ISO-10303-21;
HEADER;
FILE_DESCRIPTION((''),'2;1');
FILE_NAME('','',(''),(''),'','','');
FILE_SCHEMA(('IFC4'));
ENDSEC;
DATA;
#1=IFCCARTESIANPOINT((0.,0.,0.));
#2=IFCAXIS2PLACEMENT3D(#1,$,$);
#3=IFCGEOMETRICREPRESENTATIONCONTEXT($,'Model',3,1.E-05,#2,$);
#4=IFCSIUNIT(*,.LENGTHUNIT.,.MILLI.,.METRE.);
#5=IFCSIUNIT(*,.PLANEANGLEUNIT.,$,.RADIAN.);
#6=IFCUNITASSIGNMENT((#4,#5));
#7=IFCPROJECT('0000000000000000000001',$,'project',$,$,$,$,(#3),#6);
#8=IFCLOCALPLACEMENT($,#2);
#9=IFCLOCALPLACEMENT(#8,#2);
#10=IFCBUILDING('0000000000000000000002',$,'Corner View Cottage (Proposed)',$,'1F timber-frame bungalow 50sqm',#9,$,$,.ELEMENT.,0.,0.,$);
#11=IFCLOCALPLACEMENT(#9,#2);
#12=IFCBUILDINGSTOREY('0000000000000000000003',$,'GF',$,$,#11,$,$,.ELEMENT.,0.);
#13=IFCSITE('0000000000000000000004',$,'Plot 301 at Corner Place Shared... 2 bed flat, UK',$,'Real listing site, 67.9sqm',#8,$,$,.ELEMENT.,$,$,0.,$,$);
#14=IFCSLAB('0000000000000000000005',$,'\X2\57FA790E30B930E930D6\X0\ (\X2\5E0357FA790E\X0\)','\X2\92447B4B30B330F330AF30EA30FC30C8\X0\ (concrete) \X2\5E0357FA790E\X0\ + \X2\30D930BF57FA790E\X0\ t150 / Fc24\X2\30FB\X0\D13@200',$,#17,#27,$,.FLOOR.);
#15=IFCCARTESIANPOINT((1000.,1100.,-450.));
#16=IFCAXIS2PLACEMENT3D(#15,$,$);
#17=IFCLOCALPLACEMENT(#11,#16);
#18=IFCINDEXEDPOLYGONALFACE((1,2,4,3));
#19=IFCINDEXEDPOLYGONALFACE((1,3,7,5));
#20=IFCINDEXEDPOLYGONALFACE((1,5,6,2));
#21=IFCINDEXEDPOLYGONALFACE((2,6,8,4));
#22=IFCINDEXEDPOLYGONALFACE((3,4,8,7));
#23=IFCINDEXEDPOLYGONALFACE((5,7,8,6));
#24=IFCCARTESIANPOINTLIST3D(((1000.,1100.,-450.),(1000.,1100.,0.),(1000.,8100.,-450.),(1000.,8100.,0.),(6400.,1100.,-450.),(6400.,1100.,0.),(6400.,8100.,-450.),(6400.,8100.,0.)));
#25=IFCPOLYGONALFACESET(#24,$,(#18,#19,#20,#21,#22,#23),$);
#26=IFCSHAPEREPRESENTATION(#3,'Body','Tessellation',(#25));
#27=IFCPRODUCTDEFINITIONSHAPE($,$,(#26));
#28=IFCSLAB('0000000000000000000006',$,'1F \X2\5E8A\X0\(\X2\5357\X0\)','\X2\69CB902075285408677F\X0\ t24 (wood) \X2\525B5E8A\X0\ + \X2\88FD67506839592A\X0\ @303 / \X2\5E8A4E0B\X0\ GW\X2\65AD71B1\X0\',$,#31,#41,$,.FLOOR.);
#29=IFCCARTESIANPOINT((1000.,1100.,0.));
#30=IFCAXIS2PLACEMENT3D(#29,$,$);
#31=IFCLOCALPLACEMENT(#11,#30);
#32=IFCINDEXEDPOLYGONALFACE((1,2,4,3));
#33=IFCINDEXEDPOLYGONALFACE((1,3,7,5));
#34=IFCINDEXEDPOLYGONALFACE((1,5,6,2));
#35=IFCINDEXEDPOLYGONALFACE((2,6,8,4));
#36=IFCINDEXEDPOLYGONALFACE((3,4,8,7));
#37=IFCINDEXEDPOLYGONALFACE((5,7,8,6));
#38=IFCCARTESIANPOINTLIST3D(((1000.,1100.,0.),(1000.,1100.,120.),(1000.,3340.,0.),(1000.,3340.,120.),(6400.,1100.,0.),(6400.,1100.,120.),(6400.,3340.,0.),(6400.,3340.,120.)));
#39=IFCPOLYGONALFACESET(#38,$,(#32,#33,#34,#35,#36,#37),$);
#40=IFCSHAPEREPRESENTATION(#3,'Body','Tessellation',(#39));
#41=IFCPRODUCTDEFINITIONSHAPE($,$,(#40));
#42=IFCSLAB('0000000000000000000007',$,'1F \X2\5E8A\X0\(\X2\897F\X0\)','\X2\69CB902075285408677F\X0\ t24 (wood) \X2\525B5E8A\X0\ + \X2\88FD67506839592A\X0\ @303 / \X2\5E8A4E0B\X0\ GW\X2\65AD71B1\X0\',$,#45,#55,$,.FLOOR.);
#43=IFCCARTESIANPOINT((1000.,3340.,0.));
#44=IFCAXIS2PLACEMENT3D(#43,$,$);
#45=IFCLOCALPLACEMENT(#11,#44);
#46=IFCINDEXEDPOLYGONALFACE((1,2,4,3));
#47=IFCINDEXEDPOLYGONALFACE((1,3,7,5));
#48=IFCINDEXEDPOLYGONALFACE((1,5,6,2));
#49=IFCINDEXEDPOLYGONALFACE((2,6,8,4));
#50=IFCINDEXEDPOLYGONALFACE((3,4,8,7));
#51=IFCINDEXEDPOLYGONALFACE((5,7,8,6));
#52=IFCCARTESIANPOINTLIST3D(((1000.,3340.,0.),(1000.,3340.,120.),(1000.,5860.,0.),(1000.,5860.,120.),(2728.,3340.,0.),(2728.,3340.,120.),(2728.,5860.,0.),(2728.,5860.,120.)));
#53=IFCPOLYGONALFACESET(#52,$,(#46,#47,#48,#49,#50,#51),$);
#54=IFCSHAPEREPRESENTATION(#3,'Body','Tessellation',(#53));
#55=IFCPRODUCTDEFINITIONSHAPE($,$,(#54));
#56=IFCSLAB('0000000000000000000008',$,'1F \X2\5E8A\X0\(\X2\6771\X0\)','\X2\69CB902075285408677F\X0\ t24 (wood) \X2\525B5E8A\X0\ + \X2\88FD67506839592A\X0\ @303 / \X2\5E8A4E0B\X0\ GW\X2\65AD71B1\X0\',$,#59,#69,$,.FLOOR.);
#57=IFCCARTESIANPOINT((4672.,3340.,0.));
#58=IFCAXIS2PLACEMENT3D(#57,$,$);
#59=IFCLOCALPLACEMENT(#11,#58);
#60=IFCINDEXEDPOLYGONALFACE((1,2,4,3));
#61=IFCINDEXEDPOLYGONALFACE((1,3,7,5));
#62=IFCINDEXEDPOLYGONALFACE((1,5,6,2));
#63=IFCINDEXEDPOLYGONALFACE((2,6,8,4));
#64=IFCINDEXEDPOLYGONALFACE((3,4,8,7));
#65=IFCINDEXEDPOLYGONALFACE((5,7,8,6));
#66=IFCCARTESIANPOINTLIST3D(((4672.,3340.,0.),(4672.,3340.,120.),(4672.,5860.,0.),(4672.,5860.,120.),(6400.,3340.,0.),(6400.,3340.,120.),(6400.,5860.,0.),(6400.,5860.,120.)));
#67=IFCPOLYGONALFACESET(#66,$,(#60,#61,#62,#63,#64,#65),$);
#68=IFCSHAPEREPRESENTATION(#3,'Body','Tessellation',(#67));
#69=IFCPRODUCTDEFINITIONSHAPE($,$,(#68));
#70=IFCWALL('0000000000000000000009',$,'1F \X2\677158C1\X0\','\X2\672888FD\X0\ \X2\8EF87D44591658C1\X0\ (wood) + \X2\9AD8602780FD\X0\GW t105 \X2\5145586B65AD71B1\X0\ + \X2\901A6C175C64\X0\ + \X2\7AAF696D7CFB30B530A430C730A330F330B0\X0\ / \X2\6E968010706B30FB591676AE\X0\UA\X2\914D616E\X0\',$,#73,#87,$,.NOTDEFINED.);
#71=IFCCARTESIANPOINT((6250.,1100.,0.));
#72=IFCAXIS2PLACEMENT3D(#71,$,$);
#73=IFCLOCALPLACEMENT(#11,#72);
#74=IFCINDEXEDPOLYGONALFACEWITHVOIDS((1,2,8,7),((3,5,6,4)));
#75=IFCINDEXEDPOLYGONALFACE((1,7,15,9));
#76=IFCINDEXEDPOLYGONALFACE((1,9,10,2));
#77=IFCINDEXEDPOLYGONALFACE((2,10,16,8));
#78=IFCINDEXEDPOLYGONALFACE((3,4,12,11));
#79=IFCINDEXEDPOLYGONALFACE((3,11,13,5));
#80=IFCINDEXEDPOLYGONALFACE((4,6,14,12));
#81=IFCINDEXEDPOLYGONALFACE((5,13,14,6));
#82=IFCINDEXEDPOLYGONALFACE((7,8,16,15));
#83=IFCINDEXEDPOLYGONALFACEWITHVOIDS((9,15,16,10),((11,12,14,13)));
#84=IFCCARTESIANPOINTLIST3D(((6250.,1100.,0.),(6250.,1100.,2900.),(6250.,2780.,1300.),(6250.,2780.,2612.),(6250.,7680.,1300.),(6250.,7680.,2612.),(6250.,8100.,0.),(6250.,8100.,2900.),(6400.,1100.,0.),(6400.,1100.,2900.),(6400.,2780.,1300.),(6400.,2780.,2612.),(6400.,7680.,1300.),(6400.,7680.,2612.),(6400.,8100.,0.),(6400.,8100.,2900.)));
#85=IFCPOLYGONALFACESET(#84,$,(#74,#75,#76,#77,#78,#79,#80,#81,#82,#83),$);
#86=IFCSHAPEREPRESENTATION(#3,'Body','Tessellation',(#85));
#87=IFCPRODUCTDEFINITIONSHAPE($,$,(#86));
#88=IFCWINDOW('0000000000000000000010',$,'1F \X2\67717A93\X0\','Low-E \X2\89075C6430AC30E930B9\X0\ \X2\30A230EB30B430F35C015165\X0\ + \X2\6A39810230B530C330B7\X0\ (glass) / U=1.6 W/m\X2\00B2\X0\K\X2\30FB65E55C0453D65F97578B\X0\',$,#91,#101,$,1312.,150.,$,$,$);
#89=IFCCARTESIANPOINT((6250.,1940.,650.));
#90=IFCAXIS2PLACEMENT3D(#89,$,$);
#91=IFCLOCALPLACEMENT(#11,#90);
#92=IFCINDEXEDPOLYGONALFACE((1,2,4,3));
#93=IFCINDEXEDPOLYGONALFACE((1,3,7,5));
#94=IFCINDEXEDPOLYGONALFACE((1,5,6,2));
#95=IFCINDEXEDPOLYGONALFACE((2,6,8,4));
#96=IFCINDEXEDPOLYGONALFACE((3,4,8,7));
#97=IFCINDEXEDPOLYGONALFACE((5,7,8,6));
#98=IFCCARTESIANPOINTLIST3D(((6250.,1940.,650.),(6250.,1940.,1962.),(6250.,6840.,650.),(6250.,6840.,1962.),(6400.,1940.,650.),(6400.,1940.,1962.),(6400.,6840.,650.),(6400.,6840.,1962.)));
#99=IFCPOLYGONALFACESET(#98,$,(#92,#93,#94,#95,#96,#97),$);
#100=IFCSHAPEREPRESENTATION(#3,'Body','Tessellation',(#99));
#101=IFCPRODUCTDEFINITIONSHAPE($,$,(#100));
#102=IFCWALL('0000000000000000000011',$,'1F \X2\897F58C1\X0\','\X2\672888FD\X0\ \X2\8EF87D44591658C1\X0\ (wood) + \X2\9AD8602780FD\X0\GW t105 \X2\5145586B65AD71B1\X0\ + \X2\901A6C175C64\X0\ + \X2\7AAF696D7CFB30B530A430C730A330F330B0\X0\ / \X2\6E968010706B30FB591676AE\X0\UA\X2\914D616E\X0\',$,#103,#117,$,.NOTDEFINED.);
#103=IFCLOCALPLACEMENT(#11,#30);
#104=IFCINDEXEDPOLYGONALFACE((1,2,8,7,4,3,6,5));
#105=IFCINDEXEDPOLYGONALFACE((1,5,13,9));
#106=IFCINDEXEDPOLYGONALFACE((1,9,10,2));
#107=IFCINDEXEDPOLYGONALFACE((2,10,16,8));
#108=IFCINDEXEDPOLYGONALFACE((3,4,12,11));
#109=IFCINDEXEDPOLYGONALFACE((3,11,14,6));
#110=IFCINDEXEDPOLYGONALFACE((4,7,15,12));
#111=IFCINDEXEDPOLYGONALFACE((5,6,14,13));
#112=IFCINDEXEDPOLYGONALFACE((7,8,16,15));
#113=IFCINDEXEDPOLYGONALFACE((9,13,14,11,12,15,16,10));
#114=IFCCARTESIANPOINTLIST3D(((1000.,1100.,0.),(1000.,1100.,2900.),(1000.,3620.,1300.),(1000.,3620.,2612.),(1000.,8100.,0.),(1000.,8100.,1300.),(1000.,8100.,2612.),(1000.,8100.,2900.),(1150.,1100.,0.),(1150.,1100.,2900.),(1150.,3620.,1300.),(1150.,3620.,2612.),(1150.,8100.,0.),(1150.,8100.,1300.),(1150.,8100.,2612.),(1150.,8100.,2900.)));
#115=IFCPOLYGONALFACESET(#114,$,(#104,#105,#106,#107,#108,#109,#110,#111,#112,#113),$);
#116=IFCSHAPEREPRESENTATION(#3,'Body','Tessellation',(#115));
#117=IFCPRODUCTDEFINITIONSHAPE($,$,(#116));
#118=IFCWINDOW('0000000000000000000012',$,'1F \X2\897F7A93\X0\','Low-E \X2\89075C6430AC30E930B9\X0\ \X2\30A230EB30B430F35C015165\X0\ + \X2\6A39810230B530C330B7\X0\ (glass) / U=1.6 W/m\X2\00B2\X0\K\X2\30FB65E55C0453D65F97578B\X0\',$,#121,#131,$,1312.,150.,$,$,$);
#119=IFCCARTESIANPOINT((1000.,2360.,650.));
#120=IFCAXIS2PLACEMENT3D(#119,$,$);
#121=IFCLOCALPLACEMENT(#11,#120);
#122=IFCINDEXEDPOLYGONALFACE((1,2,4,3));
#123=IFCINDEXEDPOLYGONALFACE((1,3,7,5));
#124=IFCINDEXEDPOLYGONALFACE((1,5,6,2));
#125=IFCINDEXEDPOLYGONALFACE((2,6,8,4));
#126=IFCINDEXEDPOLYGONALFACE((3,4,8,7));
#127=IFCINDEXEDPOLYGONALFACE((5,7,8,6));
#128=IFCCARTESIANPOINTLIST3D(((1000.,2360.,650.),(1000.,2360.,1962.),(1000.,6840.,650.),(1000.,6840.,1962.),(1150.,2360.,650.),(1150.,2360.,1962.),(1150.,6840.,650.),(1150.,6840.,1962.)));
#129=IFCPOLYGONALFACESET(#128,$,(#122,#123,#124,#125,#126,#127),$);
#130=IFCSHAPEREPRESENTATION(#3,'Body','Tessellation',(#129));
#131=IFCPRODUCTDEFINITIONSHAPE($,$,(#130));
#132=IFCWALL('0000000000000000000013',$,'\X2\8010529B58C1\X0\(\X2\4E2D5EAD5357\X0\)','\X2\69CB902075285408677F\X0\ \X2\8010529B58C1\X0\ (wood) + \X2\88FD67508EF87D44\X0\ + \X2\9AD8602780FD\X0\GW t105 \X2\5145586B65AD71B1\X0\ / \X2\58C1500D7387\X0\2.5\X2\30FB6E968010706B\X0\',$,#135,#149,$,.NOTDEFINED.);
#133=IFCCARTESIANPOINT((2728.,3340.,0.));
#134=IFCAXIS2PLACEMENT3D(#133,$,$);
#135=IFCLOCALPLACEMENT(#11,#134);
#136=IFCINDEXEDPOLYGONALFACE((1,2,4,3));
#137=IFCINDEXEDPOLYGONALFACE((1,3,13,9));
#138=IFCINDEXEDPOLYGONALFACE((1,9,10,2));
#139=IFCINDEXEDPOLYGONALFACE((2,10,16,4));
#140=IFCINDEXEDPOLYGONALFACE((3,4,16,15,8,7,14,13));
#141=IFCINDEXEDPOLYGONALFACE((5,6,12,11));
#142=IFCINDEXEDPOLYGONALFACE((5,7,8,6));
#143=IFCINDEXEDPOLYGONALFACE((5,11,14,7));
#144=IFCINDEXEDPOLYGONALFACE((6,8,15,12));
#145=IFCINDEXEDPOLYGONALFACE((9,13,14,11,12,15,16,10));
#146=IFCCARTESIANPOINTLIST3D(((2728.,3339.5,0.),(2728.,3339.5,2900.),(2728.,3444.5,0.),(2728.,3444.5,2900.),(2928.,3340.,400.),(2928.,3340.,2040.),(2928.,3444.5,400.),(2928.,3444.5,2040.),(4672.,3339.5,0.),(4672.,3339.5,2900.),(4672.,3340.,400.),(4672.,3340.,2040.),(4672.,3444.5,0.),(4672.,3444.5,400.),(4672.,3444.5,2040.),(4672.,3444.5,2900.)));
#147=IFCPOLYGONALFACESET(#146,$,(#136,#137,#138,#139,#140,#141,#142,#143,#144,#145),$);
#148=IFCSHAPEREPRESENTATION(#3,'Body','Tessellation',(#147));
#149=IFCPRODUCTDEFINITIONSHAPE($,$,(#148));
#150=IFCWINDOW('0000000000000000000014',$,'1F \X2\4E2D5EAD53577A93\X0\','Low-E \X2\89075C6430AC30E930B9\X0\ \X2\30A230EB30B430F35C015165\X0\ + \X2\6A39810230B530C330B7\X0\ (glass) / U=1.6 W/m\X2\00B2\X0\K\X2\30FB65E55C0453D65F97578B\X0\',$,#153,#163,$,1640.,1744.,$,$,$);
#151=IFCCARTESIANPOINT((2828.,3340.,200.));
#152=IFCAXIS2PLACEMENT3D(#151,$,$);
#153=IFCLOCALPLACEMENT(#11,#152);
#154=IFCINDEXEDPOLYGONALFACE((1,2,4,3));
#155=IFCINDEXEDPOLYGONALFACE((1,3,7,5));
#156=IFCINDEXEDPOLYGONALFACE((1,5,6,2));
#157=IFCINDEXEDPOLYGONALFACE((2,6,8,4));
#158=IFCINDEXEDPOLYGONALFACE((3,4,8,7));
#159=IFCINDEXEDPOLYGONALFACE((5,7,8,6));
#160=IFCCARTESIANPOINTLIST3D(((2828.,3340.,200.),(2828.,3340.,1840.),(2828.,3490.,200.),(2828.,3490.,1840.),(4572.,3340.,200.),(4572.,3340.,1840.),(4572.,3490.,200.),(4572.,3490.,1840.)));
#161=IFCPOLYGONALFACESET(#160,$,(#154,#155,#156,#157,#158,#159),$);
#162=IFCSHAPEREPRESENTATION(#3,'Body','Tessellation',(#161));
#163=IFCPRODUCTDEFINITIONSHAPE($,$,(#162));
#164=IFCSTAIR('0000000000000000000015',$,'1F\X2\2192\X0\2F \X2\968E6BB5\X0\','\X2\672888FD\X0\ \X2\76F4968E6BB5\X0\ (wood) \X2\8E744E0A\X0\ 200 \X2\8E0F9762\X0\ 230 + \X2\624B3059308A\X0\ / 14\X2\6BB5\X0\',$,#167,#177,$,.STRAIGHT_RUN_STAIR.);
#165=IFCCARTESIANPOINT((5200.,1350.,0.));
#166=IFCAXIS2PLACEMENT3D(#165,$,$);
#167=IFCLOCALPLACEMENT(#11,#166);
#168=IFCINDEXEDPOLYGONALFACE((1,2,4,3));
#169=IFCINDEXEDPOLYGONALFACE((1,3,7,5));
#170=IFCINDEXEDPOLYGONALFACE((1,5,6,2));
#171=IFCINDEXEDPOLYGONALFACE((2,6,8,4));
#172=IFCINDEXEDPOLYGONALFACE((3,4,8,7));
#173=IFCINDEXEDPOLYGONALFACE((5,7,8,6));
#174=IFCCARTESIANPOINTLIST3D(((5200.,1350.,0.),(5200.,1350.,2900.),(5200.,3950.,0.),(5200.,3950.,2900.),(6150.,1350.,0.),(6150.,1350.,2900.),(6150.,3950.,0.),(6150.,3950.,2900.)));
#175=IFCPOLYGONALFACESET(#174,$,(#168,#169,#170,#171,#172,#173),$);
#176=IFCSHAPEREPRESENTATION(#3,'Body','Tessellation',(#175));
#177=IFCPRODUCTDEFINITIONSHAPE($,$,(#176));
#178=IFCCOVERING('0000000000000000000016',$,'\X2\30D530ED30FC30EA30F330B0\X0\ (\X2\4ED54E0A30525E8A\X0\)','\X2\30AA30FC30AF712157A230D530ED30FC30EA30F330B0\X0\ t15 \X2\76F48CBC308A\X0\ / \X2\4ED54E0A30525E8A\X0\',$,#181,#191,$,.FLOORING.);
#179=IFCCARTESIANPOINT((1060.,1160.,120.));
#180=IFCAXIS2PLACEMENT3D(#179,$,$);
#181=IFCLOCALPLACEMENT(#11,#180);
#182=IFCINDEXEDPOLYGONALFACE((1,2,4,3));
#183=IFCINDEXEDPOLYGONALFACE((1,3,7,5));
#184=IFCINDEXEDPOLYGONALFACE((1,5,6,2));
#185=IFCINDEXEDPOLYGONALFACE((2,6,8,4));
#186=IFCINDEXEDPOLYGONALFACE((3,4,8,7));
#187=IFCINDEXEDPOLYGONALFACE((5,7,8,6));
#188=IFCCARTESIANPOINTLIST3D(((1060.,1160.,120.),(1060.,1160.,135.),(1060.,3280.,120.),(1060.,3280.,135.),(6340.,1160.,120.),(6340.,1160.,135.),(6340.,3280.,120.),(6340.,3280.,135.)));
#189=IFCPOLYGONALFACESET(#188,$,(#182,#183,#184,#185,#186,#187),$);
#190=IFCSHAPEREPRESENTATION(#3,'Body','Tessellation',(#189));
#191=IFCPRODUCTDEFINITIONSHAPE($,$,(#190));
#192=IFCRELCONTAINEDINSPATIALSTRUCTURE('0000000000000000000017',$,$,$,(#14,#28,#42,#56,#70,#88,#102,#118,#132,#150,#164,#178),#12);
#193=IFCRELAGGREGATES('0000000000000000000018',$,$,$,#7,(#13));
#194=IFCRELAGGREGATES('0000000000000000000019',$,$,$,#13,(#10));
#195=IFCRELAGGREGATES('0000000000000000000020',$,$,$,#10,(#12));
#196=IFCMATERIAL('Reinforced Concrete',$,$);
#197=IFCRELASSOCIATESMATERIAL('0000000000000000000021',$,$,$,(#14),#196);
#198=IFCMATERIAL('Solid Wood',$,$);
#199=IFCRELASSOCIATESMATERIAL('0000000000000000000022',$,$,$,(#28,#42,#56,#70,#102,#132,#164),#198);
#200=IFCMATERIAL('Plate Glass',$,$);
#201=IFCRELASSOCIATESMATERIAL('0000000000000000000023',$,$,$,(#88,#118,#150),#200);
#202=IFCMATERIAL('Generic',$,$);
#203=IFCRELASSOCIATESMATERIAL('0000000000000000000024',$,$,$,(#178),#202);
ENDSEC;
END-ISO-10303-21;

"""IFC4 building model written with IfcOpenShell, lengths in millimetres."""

from ifc_helpers import new_model, si_unit, frame, frame_2d, origin, place, context, project, spatial, rectangle, extrude, material, element, fill, save


model = new_model("IFC4")

# Units and contexts
model_context = context("Model", 3, precision=1e-05, world=origin())
ifc_project = project(units=[si_unit("LENGTHUNIT", "METRE", prefix="MILLI"), si_unit("PLANEANGLEUNIT", "RADIAN")], contexts=[model_context])

# Site, building, storey
site_placement = place(None, origin())
site = spatial("IfcSite", under=ifc_project, at=site_placement, Name="Plot 301 at Corner Place Shared... 2 bed flat, UK", ObjectType="Real listing site, 67.9sqm", CompositionType="ELEMENT", RefElevation=0.0)
building_placement = place(site_placement, origin())
building = spatial("IfcBuilding", under=site, at=building_placement, Name="Corner View Cottage (Proposed)", ObjectType="1F timber-frame bungalow 50sqm", CompositionType="ELEMENT", ElevationOfRefHeight=0.0, ElevationOfTerrain=0.0)
storey_placement = place(building_placement, origin())
storey = spatial("IfcBuildingStorey", under=building, at=storey_placement, Name="GF", CompositionType="ELEMENT", Elevation=0.0)

# Slabs
ifc_material_1 = material(Name="Reinforced Concrete")
slab_1_placement = place(storey_placement, frame((1000.0, 1100.0, -450.0)))
element("IfcSlab", 1, at=slab_1_placement, inside=storey, material=ifc_material_1, Name="基礎スラブ (布基礎)", Description="鉄筋コンクリート (concrete) 布基礎 + ベタ基礎 t150 / Fc24・D13@200", PredefinedType="FLOOR", context=model_context, shape_type="SweptSolid", body=[
    extrude(rectangle(XDim=5400.0, YDim=7000.0, at=frame_2d((2700.0, 3500.0))), frame((1000.0, 1100.0, -450.0)), (0.0, 0.0, 1.0), 450.0),
])
ifc_material_2 = material(Name="Solid Wood")
slab_2_placement = place(storey_placement, frame((1000.0, 1100.0, 0.0)))
element("IfcSlab", 2, at=slab_2_placement, inside=storey, material=ifc_material_2, Name="1F 床(南)", Description="構造用合板 t24 (wood) 剛床 + 製材根太 @303 / 床下 GW断熱", PredefinedType="FLOOR", context=model_context, shape_type="SweptSolid", body=[
    extrude(rectangle(XDim=5400.0, YDim=2240.0, at=frame_2d((2700.0, 1120.0))), frame((1000.0, 1100.0, 0.0)), (0.0, 0.0, 1.0), 120.0),
])
slab_3_placement = place(storey_placement, frame((1000.0, 3340.0, 0.0)))
element("IfcSlab", 3, at=slab_3_placement, inside=storey, material=ifc_material_2, Name="1F 床(西)", Description="構造用合板 t24 (wood) 剛床 + 製材根太 @303 / 床下 GW断熱", PredefinedType="FLOOR", context=model_context, shape_type="SweptSolid", body=[
    extrude(rectangle(XDim=1728.0, YDim=2520.0, at=frame_2d((864.0, 1260.0))), frame((1000.0, 3340.0, 0.0)), (0.0, 0.0, 1.0), 120.0),
])
slab_4_placement = place(storey_placement, frame((4672.0, 3340.0, 0.0)))
element("IfcSlab", 4, at=slab_4_placement, inside=storey, material=ifc_material_2, Name="1F 床(東)", Description="構造用合板 t24 (wood) 剛床 + 製材根太 @303 / 床下 GW断熱", PredefinedType="FLOOR", context=model_context, shape_type="SweptSolid", body=[
    extrude(rectangle(XDim=1728.0, YDim=2520.0, at=frame_2d((864.0, 1260.0))), frame((4672.0, 3340.0, 0.0)), (0.0, 0.0, 1.0), 120.0),
])
ifc_material_3 = material(Name="Generic")

# Shared definitions
ifc_material_4 = material(Name="Plate Glass")

# Walls, openings, windows
wall_1_placement = place(storey_placement, frame((6250.0, 1100.0, 0.0)))
wall_1 = element("IfcWall", 5, at=wall_1_placement, inside=storey, material=ifc_material_2, Name="1F 東壁", Description="木製 軸組外壁 (wood) + 高性能GW t105 充填断熱 + 通気層 + 窯業系サイディング / 準耐火・外皮UA配慮", PredefinedType="NOTDEFINED", context=model_context, shape_type="SweptSolid", body=[
    extrude(rectangle(XDim=150.0, YDim=7000.0, at=frame_2d((75.0, 3500.0))), frame((6250.0, 1100.0, 0.0)), (0.0, 0.0, 1.0), 2900.0),
])
opening_1_placement = place(storey_placement, frame((6250.0, 1940.0, 650.0)))
opening_1 = element("IfcOpeningElement", 6, at=opening_1_placement, cuts=wall_1, PredefinedType="NOTDEFINED", context=model_context, shape_type="SweptSolid", body=[
    extrude(rectangle(XDim=150.0, YDim=4900.0, at=frame_2d((75.0, 2450.0))), frame((6250.0, 1940.0, 650.0)), (0.0, 0.0, 1.0), 1312.0),
])
window_1_placement = place(storey_placement, frame((6250.0, 1940.0, 650.0)))
window_1 = element("IfcWindow", 7, at=window_1_placement, inside=storey, material=ifc_material_4, Name="1F 東窓", Description="Low-E 複層ガラス アルゴン封入 + 樹脂サッシ (glass) / U=1.6 W/m²K・日射取得型", OverallHeight=1312.0, OverallWidth=150.0, context=model_context, shape_type="SweptSolid", body=[
    extrude(rectangle(XDim=150.0, YDim=4900.0, at=frame_2d((75.0, 2450.0))), frame((6250.0, 1940.0, 650.0)), (0.0, 0.0, 1.0), 1312.0),
])
fill(opening_1, window_1)
wall_2_placement = place(storey_placement, frame((1000.0, 1100.0, 0.0)))
wall_2 = element("IfcWall", 8, at=wall_2_placement, inside=storey, material=ifc_material_2, Name="1F 西壁", Description="木製 軸組外壁 (wood) + 高性能GW t105 充填断熱 + 通気層 + 窯業系サイディング / 準耐火・外皮UA配慮", PredefinedType="NOTDEFINED", context=model_context, shape_type="SweptSolid", body=[
    extrude(rectangle(XDim=150.0, YDim=7000.0, at=frame_2d((75.0, 3500.0))), frame((1000.0, 1100.0, 0.0)), (0.0, 0.0, 1.0), 2900.0),
])
opening_2_placement = place(storey_placement, frame((1000.0, 2360.0, 650.0)))
opening_2 = element("IfcOpeningElement", 9, at=opening_2_placement, cuts=wall_2, PredefinedType="NOTDEFINED", context=model_context, shape_type="SweptSolid", body=[
    extrude(rectangle(XDim=150.0, YDim=4480.0, at=frame_2d((75.0, 2240.0))), frame((1000.0, 2360.0, 650.0)), (0.0, 0.0, 1.0), 1312.0),
])
window_2_placement = place(storey_placement, frame((1000.0, 2360.0, 650.0)))
window_2 = element("IfcWindow", 10, at=window_2_placement, inside=storey, material=ifc_material_4, Name="1F 西窓", Description="Low-E 複層ガラス アルゴン封入 + 樹脂サッシ (glass) / U=1.6 W/m²K・日射取得型", OverallHeight=1312.0, OverallWidth=150.0, context=model_context, shape_type="SweptSolid", body=[
    extrude(rectangle(XDim=150.0, YDim=4480.0, at=frame_2d((75.0, 2240.0))), frame((1000.0, 2360.0, 650.0)), (0.0, 0.0, 1.0), 1312.0),
])
fill(opening_2, window_2)
wall_3_placement = place(storey_placement, frame((2728.0, 3340.0, 0.0)))
wall_3 = element("IfcWall", 11, at=wall_3_placement, inside=storey, material=ifc_material_2, Name="耐力壁(中庭南)", Description="構造用合板 耐力壁 (wood) + 製材軸組 + 高性能GW t105 充填断熱 / 壁倍率2.5・準耐火", PredefinedType="NOTDEFINED", context=model_context, shape_type="SweptSolid", body=[
    extrude(rectangle(XDim=1944.0, YDim=105.0, at=frame_2d((972.0, 52.0))), frame((2728.0, 3340.0, 0.0)), (0.0, 0.0, 1.0), 2900.0),
])
opening_3_placement = place(storey_placement, frame((2828.0, 3340.0, 200.0)))
opening_3 = element("IfcOpeningElement", 12, at=opening_3_placement, cuts=wall_3, PredefinedType="NOTDEFINED", context=model_context, shape_type="SweptSolid", body=[
    extrude(rectangle(XDim=1744.0, YDim=150.0, at=frame_2d((872.0, 75.0))), frame((2828.0, 3340.0, 200.0)), (0.0, 0.0, 1.0), 1640.0),
])
window_3_placement = place(storey_placement, frame((2828.0, 3340.0, 200.0)))
window_3 = element("IfcWindow", 13, at=window_3_placement, inside=storey, material=ifc_material_4, Name="1F 中庭南窓", Description="Low-E 複層ガラス アルゴン封入 + 樹脂サッシ (glass) / U=1.6 W/m²K・日射取得型", OverallHeight=1640.0, OverallWidth=1744.0, context=model_context, shape_type="SweptSolid", body=[
    extrude(rectangle(XDim=1744.0, YDim=150.0, at=frame_2d((872.0, 75.0))), frame((2828.0, 3340.0, 200.0)), (0.0, 0.0, 1.0), 1640.0),
])
fill(opening_3, window_3)

# Stair
stair_placement = place(storey_placement, frame((5200.0, 1350.0, 0.0)))
element("IfcStair", 14, at=stair_placement, inside=storey, material=ifc_material_2, Name="1F→2F 階段", Description="木製 直階段 (wood) 蹴上 200 踏面 230 + 手すり / 14段", PredefinedType="STRAIGHT_RUN_STAIR", context=model_context, shape_type="SweptSolid", body=[
    extrude(rectangle(XDim=950.0, YDim=2600.0, at=frame_2d((475.0, 1300.0))), frame((5200.0, 1350.0, 0.0)), (0.0, 0.0, 1.0), 2900.0),
])

# Covering
covering_placement = place(storey_placement, frame((1060.0, 1160.0, 120.0)))
element("IfcCovering", 15, at=covering_placement, inside=storey, material=ifc_material_3, Name="フローリング (仕上げ床)", Description="オーク無垢フローリング t15 直貼り / 仕上げ床", PredefinedType="FLOORING", context=model_context, shape_type="SweptSolid", body=[
    extrude(rectangle(XDim=5280.0, YDim=2120.0, at=frame_2d((2640.0, 1060.0))), frame((1060.0, 1160.0, 120.0)), (0.0, 0.0, 1.0), 15.0),
])

save(model, "model.ifc")
